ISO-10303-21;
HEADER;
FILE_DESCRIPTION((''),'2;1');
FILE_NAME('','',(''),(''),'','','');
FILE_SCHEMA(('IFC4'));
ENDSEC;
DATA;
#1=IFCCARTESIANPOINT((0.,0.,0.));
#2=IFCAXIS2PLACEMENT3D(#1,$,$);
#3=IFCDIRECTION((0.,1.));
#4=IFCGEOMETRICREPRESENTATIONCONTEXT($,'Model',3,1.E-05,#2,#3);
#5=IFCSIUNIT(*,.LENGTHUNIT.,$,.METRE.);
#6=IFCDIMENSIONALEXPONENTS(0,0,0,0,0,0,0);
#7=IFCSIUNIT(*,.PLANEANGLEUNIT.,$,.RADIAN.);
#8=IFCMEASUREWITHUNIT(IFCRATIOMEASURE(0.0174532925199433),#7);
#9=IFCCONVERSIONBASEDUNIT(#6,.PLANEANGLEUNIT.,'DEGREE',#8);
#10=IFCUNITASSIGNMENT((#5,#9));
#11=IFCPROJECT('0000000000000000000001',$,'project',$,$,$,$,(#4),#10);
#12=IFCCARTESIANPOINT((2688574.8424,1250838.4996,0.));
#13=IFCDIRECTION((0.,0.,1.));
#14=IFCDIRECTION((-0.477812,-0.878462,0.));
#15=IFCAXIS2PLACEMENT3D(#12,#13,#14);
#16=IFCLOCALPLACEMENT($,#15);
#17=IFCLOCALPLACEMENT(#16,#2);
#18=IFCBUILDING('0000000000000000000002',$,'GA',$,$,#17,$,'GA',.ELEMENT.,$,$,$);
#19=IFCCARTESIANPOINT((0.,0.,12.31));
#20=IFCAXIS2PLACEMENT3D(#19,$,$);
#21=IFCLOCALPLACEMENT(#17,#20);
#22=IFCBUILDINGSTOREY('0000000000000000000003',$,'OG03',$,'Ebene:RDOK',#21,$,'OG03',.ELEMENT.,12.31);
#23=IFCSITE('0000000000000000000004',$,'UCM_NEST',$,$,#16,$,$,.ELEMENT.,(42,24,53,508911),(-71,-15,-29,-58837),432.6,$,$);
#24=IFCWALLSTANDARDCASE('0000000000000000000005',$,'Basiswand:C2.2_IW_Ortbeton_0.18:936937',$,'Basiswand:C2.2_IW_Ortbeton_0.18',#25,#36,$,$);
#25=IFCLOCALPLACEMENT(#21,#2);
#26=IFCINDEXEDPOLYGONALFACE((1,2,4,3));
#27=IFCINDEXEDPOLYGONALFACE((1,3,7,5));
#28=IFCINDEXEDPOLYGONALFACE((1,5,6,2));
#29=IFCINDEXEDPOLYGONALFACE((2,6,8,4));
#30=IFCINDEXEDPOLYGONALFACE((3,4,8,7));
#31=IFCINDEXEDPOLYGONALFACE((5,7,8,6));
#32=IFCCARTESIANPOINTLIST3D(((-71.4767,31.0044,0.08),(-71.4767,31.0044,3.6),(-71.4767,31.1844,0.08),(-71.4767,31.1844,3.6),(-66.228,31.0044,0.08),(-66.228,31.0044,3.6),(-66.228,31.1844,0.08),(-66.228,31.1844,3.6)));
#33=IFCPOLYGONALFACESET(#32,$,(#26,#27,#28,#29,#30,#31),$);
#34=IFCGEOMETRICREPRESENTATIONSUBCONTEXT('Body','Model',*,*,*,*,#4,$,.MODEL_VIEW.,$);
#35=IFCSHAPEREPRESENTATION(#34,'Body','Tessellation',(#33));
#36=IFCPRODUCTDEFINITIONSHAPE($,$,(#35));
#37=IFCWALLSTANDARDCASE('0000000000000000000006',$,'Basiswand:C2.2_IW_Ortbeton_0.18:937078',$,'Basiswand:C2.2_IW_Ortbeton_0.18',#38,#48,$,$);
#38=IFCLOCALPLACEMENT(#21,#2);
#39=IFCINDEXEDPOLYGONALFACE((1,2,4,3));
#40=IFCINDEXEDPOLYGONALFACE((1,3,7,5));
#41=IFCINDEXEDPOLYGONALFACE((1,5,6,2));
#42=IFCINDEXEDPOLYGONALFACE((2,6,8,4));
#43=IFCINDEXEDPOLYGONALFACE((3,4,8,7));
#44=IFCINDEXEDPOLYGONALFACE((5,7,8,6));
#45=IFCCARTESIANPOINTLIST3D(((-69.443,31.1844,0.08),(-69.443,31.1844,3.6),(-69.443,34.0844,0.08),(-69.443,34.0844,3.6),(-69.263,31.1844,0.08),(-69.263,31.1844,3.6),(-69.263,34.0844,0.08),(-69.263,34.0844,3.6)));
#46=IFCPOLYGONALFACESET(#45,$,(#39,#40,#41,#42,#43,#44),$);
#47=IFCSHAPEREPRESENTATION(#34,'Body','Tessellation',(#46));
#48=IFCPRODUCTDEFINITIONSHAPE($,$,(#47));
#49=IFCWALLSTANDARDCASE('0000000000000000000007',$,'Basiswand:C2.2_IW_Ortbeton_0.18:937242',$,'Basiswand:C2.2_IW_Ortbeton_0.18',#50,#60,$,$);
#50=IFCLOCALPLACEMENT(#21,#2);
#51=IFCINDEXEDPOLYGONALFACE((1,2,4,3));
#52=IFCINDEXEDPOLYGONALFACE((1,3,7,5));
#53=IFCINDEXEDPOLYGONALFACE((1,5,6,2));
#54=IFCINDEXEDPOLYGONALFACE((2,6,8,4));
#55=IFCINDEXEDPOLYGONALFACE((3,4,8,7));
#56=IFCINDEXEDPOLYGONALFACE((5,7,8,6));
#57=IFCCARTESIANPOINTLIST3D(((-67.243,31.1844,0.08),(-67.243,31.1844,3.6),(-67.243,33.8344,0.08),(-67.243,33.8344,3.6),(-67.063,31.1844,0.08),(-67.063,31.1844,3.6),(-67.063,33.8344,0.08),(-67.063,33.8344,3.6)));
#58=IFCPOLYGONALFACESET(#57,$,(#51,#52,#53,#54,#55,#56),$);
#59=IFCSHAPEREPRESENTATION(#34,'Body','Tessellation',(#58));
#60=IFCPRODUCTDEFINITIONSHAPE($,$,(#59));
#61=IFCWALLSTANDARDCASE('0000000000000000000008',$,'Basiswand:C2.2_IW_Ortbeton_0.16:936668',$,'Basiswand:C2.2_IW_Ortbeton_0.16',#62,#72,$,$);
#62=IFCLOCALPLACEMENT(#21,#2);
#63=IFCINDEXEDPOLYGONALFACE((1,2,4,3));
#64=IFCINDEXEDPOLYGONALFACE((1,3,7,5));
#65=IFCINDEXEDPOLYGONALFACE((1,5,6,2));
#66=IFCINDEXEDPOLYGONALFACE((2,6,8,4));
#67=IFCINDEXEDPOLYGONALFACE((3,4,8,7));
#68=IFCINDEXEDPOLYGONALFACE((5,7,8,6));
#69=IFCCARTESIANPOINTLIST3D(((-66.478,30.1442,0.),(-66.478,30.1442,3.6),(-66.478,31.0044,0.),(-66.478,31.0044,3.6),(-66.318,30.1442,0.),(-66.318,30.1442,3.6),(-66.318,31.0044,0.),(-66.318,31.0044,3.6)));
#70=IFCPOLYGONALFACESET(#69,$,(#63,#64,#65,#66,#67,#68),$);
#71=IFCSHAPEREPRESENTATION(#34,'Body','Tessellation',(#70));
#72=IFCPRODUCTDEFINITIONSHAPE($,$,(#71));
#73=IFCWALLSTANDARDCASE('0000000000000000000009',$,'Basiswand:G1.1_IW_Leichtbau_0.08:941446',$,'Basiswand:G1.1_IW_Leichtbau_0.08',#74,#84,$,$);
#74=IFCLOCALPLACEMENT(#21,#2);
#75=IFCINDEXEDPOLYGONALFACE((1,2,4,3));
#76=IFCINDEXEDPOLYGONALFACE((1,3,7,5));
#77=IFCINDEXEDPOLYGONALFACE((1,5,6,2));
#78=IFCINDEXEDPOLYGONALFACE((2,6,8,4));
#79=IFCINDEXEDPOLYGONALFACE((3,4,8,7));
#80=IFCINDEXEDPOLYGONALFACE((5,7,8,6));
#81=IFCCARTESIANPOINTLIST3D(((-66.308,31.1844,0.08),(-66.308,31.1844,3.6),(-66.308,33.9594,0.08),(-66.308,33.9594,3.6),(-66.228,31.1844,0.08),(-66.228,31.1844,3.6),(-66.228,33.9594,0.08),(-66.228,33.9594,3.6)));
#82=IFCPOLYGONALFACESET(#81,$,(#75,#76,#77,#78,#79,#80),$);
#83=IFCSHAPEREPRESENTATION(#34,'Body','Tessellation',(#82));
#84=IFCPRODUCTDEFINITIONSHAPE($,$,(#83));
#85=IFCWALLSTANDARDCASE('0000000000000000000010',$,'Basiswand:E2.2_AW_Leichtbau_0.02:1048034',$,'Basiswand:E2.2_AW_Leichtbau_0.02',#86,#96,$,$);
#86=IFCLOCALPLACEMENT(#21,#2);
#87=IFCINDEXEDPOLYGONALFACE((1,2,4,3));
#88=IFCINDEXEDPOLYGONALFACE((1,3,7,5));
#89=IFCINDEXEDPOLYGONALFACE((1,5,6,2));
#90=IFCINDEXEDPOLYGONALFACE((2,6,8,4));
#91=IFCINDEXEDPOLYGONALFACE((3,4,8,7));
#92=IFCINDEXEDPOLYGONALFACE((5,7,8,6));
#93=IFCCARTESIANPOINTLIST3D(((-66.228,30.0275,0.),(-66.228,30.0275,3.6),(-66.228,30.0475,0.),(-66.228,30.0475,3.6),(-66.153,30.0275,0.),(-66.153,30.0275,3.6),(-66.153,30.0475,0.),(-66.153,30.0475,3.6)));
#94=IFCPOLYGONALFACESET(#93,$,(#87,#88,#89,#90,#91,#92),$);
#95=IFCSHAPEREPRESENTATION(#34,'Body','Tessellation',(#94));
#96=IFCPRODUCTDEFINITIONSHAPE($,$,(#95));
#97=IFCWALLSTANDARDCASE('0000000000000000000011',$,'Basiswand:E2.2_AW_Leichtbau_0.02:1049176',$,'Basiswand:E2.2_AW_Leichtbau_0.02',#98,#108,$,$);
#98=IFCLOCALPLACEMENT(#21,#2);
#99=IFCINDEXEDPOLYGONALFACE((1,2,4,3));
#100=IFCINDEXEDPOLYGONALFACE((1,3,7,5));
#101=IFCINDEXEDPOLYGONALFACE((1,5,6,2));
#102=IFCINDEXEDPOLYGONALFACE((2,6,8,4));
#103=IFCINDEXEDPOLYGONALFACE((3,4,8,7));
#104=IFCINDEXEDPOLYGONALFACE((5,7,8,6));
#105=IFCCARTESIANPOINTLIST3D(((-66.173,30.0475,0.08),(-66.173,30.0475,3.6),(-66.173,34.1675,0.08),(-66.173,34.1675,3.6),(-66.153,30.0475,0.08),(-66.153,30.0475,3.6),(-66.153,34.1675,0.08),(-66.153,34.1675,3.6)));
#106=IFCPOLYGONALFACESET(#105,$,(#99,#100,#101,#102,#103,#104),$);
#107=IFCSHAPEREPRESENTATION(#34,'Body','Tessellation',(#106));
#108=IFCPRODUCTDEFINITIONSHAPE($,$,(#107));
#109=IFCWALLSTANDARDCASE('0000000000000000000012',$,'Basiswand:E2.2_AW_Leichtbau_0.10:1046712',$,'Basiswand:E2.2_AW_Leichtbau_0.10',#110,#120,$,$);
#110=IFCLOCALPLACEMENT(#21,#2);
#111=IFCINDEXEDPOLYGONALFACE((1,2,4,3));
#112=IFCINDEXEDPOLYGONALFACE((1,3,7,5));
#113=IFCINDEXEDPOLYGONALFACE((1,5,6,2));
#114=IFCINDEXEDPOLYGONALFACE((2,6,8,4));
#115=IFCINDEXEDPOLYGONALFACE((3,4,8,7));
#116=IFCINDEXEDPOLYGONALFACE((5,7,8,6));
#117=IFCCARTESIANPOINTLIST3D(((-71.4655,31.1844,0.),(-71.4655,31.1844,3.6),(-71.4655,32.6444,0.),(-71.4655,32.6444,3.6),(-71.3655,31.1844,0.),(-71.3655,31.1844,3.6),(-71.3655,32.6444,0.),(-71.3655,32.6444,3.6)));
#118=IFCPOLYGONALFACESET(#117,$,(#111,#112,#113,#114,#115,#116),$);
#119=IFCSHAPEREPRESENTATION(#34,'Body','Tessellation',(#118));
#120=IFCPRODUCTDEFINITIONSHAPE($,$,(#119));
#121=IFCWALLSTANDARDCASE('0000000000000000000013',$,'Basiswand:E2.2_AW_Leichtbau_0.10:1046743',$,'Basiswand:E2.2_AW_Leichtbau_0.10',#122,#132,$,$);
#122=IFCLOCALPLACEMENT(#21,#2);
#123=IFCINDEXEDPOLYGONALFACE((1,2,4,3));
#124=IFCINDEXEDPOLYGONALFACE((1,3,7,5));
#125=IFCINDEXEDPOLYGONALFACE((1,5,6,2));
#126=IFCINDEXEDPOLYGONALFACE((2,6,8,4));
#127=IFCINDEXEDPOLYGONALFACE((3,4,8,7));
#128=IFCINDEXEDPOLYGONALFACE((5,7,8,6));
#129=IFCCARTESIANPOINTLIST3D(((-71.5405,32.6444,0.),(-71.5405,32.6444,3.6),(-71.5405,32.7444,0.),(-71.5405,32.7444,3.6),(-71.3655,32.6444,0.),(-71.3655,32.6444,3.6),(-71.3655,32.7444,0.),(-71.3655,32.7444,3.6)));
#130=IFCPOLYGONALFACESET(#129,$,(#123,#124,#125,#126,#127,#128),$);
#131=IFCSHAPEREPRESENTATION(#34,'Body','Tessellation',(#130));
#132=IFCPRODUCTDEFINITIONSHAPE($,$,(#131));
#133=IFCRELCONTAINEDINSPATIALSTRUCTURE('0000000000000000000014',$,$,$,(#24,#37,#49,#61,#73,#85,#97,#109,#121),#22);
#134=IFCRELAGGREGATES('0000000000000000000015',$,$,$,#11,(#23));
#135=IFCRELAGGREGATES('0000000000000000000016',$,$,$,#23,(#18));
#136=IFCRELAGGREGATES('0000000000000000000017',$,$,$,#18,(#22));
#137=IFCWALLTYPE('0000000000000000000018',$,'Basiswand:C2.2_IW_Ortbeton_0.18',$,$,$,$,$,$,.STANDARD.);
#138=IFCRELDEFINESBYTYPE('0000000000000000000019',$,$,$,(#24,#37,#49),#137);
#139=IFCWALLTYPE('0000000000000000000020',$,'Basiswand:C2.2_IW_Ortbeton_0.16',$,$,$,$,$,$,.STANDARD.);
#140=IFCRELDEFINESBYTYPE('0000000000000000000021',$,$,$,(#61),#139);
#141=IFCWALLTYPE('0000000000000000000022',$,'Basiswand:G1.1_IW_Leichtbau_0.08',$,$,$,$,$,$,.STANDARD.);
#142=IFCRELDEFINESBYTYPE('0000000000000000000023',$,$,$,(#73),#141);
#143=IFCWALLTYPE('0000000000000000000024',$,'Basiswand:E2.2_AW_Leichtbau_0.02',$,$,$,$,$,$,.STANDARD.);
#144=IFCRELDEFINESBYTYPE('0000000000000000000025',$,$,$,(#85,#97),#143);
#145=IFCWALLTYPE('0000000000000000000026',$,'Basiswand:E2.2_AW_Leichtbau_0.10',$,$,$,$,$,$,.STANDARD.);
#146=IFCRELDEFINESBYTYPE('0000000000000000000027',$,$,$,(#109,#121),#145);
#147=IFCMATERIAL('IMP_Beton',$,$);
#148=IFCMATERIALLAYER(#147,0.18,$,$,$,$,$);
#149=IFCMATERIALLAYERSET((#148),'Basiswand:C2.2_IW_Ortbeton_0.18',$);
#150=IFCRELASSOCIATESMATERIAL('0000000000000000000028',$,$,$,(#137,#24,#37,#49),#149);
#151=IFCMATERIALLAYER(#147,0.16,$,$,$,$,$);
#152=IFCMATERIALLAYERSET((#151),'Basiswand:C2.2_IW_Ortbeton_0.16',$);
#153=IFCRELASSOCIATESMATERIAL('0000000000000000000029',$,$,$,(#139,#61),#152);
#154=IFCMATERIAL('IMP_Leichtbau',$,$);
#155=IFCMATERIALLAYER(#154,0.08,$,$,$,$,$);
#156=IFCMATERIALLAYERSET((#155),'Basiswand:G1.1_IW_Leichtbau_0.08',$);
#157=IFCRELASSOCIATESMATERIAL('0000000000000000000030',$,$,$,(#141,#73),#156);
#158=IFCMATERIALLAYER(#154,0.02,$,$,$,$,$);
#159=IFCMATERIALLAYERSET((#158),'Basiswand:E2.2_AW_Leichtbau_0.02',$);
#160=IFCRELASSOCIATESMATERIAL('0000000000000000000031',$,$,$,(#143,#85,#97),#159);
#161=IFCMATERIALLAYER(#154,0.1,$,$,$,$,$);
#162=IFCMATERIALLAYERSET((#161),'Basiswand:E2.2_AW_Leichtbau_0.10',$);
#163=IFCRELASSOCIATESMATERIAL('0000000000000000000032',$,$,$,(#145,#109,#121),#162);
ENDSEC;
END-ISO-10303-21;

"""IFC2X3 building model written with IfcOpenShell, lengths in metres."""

from ifc_helpers import new_model, entity, si_unit, converted_unit, direction, frame, frame_2d, origin, place, context, subcontext, project, spatial, polyline, rectangle, extrude, clip, bounded_halfspace, material, layer, layer_set, layer_usage, type_object, element, save


model = new_model("IFC2X3")

# Units and contexts
model_context = context("Model", 3, precision=1e-05, world=origin(), true_north=direction((0.0, 1.0)))
body_context = subcontext(model_context, "Body", "Model", "MODEL_VIEW")
ifc_project = project(units=[si_unit("LENGTHUNIT", "METRE"), converted_unit("PLANEANGLEUNIT", "DEGREE", entity("IfcRatioMeasure", 0.0174532925199433), si_unit("PLANEANGLEUNIT", "RADIAN"), dimensions=[0, 0, 0, 0, 0, 0, 0])], contexts=[model_context])

# Site, building, storey
site_placement = place(None, frame((2688574.8424, 1250838.4996, 0.0), z_axis=(0.0, 0.0, 1.0), x_axis=(-0.477812, -0.878462, 0.0)))
site = spatial("IfcSite", under=ifc_project, at=site_placement, Name="UCM_NEST", CompositionType="ELEMENT", RefLatitude=(42, 24, 53, 508911), RefLongitude=(-71, -15, -29, -58837), RefElevation=432.6)
building_placement = place(site_placement, origin())
building = spatial("IfcBuilding", under=site, at=building_placement, Name="GA", LongName="GA", CompositionType="ELEMENT")
storey_placement = place(building_placement, frame((0.0, 0.0, 12.31)))
storey = spatial("IfcBuildingStorey", under=building, at=storey_placement, Name="OG03", ObjectType="Ebene:RDOK", LongName="OG03", CompositionType="ELEMENT", Elevation=12.31)

# Shared definitions
ifc_material_1 = material(Name="IMP_Beton")

# Walls
ifc_material_2 = material(Name="IMP_Leichtbau")
ifc_layer_1 = layer(ifc_material_1, 0.18)
ifc_layer_set_1 = layer_set([ifc_layer_1], Name="Basiswand:C2.2_IW_Ortbeton_0.18")
ifc_layer_usage_1 = layer_usage(ifc_layer_set_1, "AXIS2", "NEGATIVE", 0.09)
wall_type_1 = type_object("IfcWallType", Name="Basiswand:C2.2_IW_Ortbeton_0.18", PredefinedType="STANDARD", material=ifc_layer_set_1)
wall_1_placement = place(storey_placement, frame((-66.228, 31.0944, 0.08), z_axis=(0.0, 0.0, 1.0), x_axis=(-1.0, 0.0, 0.0)))
element("IfcWallStandardCase", 1, at=wall_1_placement, inside=storey, type_object=wall_type_1, material=ifc_layer_usage_1, Name="Basiswand:C2.2_IW_Ortbeton_0.18:936937", ObjectType="Basiswand:C2.2_IW_Ortbeton_0.18", context=body_context, shape_type="Clipping", body=[
    clip(extrude(rectangle(XDim=5.2488, YDim=0.18, at=frame_2d((2.6244, 0.0), x_axis=(-1.0, 0.0))), origin(), (0.0, 0.0, 1.0), 3.52), bounded_halfspace(frame((5.2488, -0.09, 0.0)), True, frame((5.2488, -0.09, 0.0)), polyline([(0.0, 0.0), (0.0, 0.18), (-5.2488, 0.18), (-5.2488, 0.0), (-4.4137, 0.0), (-4.2337, 0.0), (-2.2137, 0.0), (-2.0337, 0.0), (0.0, 0.0)]))),
])
ifc_layer_usage_2 = layer_usage(ifc_layer_set_1, "AXIS2", "NEGATIVE", 0.09)
wall_2_placement = place(storey_placement, frame((-69.353, 31.1844, 0.08), z_axis=(0.0, 0.0, 1.0), x_axis=(0.0, 1.0, 0.0)))
element("IfcWallStandardCase", 2, at=wall_2_placement, inside=storey, type_object=wall_type_1, material=ifc_layer_usage_2, Name="Basiswand:C2.2_IW_Ortbeton_0.18:937078", ObjectType="Basiswand:C2.2_IW_Ortbeton_0.18", context=body_context, shape_type="Clipping", body=[
    clip(extrude(rectangle(XDim=2.9, YDim=0.18, at=frame_2d((1.45, 0.0), x_axis=(-1.0, 0.0))), origin(), (0.0, 0.0, 1.0), 3.52), bounded_halfspace(frame((2.9, -0.09, 0.0), z_axis=(0.0, 0.0, 1.0), x_axis=(0.0, 1.0, 0.0)), True, frame((2.9, -0.09, 0.0), z_axis=(0.0, 0.0, 1.0), x_axis=(0.0, 1.0, 0.0)), polyline([(0.0, 0.0), (0.18, 0.0), (0.18, 2.9), (0.0, 2.9), (0.0, 0.25), (0.0, 0.0)]))),
])
ifc_layer_usage_3 = layer_usage(ifc_layer_set_1, "AXIS2", "NEGATIVE", 0.09)
wall_3_placement = place(storey_placement, frame((-67.153, 33.8344, 0.08), z_axis=(0.0, 0.0, 1.0), x_axis=(0.0, -1.0, 0.0)))
element("IfcWallStandardCase", 3, at=wall_3_placement, inside=storey, type_object=wall_type_1, material=ifc_layer_usage_3, Name="Basiswand:C2.2_IW_Ortbeton_0.18:937242", ObjectType="Basiswand:C2.2_IW_Ortbeton_0.18", context=body_context, shape_type="Clipping", body=[
    clip(extrude(rectangle(XDim=2.65, YDim=0.18, at=frame_2d((1.325, 0.0), x_axis=(-1.0, 0.0))), origin(), (0.0, 0.0, 1.0), 3.52), bounded_halfspace(frame((2.65, -0.09, 0.0), z_axis=(0.0, 0.0, 1.0), x_axis=(0.0, -1.0, 0.0)), True, frame((2.65, -0.09, 0.0), z_axis=(0.0, 0.0, 1.0), x_axis=(0.0, -1.0, 0.0)), polyline([(0.0, 0.0), (-0.18, 0.0), (-0.18, -2.65), (0.0, -2.65), (0.0, 0.0)]))),
])
ifc_layer_2 = layer(ifc_material_1, 0.16)
ifc_layer_set_2 = layer_set([ifc_layer_2], Name="Basiswand:C2.2_IW_Ortbeton_0.16")
ifc_layer_usage_4 = layer_usage(ifc_layer_set_2, "AXIS2", "NEGATIVE", 0.08)
wall_type_2 = type_object("IfcWallType", Name="Basiswand:C2.2_IW_Ortbeton_0.16", PredefinedType="STANDARD", material=ifc_layer_set_2)
wall_4_placement = place(storey_placement, frame((-66.398, 31.0044, 0.0), z_axis=(0.0, 0.0, 1.0), x_axis=(0.0, -1.0, 0.0)))
element("IfcWallStandardCase", 4, at=wall_4_placement, inside=storey, type_object=wall_type_2, material=ifc_layer_usage_4, Name="Basiswand:C2.2_IW_Ortbeton_0.16:936668", ObjectType="Basiswand:C2.2_IW_Ortbeton_0.16", context=body_context, shape_type="SweptSolid", body=[
    extrude(rectangle(XDim=0.8603, YDim=0.16, at=frame_2d((0.4301, 0.0), x_axis=(-1.0, 0.0))), origin(), (0.0, 0.0, 1.0), 3.6),
])
ifc_layer_3 = layer(ifc_material_2, 0.08)
ifc_layer_set_3 = layer_set([ifc_layer_3], Name="Basiswand:G1.1_IW_Leichtbau_0.08")
ifc_layer_usage_5 = layer_usage(ifc_layer_set_3, "AXIS2", "NEGATIVE", 0.04)
wall_type_3 = type_object("IfcWallType", Name="Basiswand:G1.1_IW_Leichtbau_0.08", PredefinedType="STANDARD", material=ifc_layer_set_3)
wall_5_placement = place(storey_placement, frame((-66.268, 33.9594, 0.08), z_axis=(0.0, 0.0, 1.0), x_axis=(0.0, -1.0, 0.0)))
element("IfcWallStandardCase", 5, at=wall_5_placement, inside=storey, type_object=wall_type_3, material=ifc_layer_usage_5, Name="Basiswand:G1.1_IW_Leichtbau_0.08:941446", ObjectType="Basiswand:G1.1_IW_Leichtbau_0.08", context=body_context, shape_type="Clipping", body=[
    clip(extrude(rectangle(XDim=2.775, YDim=0.08, at=frame_2d((1.3875, 0.0), x_axis=(-1.0, 0.0))), origin(), (0.0, 0.0, 1.0), 3.52), bounded_halfspace(frame((2.775, -0.04, 0.0), z_axis=(0.0, 0.0, 1.0), x_axis=(0.0, -1.0, 0.0)), True, frame((2.775, -0.04, 0.0), z_axis=(0.0, 0.0, 1.0), x_axis=(0.0, -1.0, 0.0)), polyline([(0.0, 0.0), (-0.08, 0.0), (-0.08, -2.775), (-0.03, -2.775), (0.0, -2.775), (0.0, 0.0)]))),
])

# Walls
ifc_layer_4 = layer(ifc_material_2, 0.02)
ifc_layer_set_4 = layer_set([ifc_layer_4], Name="Basiswand:E2.2_AW_Leichtbau_0.02")
ifc_layer_usage_6 = layer_usage(ifc_layer_set_4, "AXIS2", "NEGATIVE", 0.01)
wall_type_4 = type_object("IfcWallType", Name="Basiswand:E2.2_AW_Leichtbau_0.02", PredefinedType="STANDARD", material=ifc_layer_set_4)
wall_6_placement = place(storey_placement, frame((-66.228, 30.0375, 0.0)))
element("IfcWallStandardCase", 6, at=wall_6_placement, inside=storey, type_object=wall_type_4, material=ifc_layer_usage_6, Name="Basiswand:E2.2_AW_Leichtbau_0.02:1048034", ObjectType="Basiswand:E2.2_AW_Leichtbau_0.02", context=body_context, shape_type="SweptSolid", body=[
    extrude(rectangle(XDim=0.075, YDim=0.02, at=frame_2d((0.0375, 0.0), x_axis=(-1.0, 0.0))), origin(), (0.0, 0.0, 1.0), 3.6),
])
ifc_layer_usage_7 = layer_usage(ifc_layer_set_4, "AXIS2", "NEGATIVE", 0.01)
wall_7_placement = place(storey_placement, frame((-66.163, 30.0475, 0.08), z_axis=(0.0, 0.0, 1.0), x_axis=(0.0, 1.0, 0.0)))
element("IfcWallStandardCase", 7, at=wall_7_placement, inside=storey, type_object=wall_type_4, material=ifc_layer_usage_7, Name="Basiswand:E2.2_AW_Leichtbau_0.02:1049176", ObjectType="Basiswand:E2.2_AW_Leichtbau_0.02", context=body_context, shape_type="Clipping", body=[
    clip(extrude(rectangle(XDim=4.12, YDim=0.02, at=frame_2d((2.06, 0.0), x_axis=(-1.0, 0.0))), origin(), (0.0, 0.0, 1.0), 3.52), bounded_halfspace(frame((4.12, -0.01, 0.0), z_axis=(0.0, 0.0, 1.0), x_axis=(0.0, 1.0, 0.0)), True, frame((4.12, -0.01, 0.0), z_axis=(0.0, 0.0, 1.0), x_axis=(0.0, 1.0, 0.0)), polyline([(0.0, 0.0), (0.02, 0.0), (0.02, 4.12), (0.0, 4.12), (0.0, 0.0)]))),
])
ifc_layer_5 = layer(ifc_material_2, 0.1)
ifc_layer_set_5 = layer_set([ifc_layer_5], Name="Basiswand:E2.2_AW_Leichtbau_0.10")
ifc_layer_usage_8 = layer_usage(ifc_layer_set_5, "AXIS2", "NEGATIVE", 0.05)
wall_type_5 = type_object("IfcWallType", Name="Basiswand:E2.2_AW_Leichtbau_0.10", PredefinedType="STANDARD", material=ifc_layer_set_5)
wall_8_placement = place(storey_placement, frame((-71.4155, 31.1844, 0.0), z_axis=(0.0, 0.0, 1.0), x_axis=(0.0, 1.0, 0.0)))
element("IfcWallStandardCase", 8, at=wall_8_placement, inside=storey, type_object=wall_type_5, material=ifc_layer_usage_8, Name="Basiswand:E2.2_AW_Leichtbau_0.10:1046712", ObjectType="Basiswand:E2.2_AW_Leichtbau_0.10", context=body_context, shape_type="SweptSolid", body=[
    extrude(rectangle(XDim=1.46, YDim=0.1, at=frame_2d((0.73, 0.0), x_axis=(-1.0, 0.0))), origin(), (0.0, 0.0, 1.0), 3.6),
])
ifc_layer_usage_9 = layer_usage(ifc_layer_set_5, "AXIS2", "NEGATIVE", 0.05)
wall_9_placement = place(storey_placement, frame((-71.5405, 32.6944, 0.0)))
element("IfcWallStandardCase", 9, at=wall_9_placement, inside=storey, type_object=wall_type_5, material=ifc_layer_usage_9, Name="Basiswand:E2.2_AW_Leichtbau_0.10:1046743", ObjectType="Basiswand:E2.2_AW_Leichtbau_0.10", context=body_context, shape_type="SweptSolid", body=[
    extrude(rectangle(XDim=0.175, YDim=0.1, at=frame_2d((0.0875, 0.0), x_axis=(-1.0, 0.0))), origin(), (0.0, 0.0, 1.0), 3.6),
])

save(model, "model.ifc")
